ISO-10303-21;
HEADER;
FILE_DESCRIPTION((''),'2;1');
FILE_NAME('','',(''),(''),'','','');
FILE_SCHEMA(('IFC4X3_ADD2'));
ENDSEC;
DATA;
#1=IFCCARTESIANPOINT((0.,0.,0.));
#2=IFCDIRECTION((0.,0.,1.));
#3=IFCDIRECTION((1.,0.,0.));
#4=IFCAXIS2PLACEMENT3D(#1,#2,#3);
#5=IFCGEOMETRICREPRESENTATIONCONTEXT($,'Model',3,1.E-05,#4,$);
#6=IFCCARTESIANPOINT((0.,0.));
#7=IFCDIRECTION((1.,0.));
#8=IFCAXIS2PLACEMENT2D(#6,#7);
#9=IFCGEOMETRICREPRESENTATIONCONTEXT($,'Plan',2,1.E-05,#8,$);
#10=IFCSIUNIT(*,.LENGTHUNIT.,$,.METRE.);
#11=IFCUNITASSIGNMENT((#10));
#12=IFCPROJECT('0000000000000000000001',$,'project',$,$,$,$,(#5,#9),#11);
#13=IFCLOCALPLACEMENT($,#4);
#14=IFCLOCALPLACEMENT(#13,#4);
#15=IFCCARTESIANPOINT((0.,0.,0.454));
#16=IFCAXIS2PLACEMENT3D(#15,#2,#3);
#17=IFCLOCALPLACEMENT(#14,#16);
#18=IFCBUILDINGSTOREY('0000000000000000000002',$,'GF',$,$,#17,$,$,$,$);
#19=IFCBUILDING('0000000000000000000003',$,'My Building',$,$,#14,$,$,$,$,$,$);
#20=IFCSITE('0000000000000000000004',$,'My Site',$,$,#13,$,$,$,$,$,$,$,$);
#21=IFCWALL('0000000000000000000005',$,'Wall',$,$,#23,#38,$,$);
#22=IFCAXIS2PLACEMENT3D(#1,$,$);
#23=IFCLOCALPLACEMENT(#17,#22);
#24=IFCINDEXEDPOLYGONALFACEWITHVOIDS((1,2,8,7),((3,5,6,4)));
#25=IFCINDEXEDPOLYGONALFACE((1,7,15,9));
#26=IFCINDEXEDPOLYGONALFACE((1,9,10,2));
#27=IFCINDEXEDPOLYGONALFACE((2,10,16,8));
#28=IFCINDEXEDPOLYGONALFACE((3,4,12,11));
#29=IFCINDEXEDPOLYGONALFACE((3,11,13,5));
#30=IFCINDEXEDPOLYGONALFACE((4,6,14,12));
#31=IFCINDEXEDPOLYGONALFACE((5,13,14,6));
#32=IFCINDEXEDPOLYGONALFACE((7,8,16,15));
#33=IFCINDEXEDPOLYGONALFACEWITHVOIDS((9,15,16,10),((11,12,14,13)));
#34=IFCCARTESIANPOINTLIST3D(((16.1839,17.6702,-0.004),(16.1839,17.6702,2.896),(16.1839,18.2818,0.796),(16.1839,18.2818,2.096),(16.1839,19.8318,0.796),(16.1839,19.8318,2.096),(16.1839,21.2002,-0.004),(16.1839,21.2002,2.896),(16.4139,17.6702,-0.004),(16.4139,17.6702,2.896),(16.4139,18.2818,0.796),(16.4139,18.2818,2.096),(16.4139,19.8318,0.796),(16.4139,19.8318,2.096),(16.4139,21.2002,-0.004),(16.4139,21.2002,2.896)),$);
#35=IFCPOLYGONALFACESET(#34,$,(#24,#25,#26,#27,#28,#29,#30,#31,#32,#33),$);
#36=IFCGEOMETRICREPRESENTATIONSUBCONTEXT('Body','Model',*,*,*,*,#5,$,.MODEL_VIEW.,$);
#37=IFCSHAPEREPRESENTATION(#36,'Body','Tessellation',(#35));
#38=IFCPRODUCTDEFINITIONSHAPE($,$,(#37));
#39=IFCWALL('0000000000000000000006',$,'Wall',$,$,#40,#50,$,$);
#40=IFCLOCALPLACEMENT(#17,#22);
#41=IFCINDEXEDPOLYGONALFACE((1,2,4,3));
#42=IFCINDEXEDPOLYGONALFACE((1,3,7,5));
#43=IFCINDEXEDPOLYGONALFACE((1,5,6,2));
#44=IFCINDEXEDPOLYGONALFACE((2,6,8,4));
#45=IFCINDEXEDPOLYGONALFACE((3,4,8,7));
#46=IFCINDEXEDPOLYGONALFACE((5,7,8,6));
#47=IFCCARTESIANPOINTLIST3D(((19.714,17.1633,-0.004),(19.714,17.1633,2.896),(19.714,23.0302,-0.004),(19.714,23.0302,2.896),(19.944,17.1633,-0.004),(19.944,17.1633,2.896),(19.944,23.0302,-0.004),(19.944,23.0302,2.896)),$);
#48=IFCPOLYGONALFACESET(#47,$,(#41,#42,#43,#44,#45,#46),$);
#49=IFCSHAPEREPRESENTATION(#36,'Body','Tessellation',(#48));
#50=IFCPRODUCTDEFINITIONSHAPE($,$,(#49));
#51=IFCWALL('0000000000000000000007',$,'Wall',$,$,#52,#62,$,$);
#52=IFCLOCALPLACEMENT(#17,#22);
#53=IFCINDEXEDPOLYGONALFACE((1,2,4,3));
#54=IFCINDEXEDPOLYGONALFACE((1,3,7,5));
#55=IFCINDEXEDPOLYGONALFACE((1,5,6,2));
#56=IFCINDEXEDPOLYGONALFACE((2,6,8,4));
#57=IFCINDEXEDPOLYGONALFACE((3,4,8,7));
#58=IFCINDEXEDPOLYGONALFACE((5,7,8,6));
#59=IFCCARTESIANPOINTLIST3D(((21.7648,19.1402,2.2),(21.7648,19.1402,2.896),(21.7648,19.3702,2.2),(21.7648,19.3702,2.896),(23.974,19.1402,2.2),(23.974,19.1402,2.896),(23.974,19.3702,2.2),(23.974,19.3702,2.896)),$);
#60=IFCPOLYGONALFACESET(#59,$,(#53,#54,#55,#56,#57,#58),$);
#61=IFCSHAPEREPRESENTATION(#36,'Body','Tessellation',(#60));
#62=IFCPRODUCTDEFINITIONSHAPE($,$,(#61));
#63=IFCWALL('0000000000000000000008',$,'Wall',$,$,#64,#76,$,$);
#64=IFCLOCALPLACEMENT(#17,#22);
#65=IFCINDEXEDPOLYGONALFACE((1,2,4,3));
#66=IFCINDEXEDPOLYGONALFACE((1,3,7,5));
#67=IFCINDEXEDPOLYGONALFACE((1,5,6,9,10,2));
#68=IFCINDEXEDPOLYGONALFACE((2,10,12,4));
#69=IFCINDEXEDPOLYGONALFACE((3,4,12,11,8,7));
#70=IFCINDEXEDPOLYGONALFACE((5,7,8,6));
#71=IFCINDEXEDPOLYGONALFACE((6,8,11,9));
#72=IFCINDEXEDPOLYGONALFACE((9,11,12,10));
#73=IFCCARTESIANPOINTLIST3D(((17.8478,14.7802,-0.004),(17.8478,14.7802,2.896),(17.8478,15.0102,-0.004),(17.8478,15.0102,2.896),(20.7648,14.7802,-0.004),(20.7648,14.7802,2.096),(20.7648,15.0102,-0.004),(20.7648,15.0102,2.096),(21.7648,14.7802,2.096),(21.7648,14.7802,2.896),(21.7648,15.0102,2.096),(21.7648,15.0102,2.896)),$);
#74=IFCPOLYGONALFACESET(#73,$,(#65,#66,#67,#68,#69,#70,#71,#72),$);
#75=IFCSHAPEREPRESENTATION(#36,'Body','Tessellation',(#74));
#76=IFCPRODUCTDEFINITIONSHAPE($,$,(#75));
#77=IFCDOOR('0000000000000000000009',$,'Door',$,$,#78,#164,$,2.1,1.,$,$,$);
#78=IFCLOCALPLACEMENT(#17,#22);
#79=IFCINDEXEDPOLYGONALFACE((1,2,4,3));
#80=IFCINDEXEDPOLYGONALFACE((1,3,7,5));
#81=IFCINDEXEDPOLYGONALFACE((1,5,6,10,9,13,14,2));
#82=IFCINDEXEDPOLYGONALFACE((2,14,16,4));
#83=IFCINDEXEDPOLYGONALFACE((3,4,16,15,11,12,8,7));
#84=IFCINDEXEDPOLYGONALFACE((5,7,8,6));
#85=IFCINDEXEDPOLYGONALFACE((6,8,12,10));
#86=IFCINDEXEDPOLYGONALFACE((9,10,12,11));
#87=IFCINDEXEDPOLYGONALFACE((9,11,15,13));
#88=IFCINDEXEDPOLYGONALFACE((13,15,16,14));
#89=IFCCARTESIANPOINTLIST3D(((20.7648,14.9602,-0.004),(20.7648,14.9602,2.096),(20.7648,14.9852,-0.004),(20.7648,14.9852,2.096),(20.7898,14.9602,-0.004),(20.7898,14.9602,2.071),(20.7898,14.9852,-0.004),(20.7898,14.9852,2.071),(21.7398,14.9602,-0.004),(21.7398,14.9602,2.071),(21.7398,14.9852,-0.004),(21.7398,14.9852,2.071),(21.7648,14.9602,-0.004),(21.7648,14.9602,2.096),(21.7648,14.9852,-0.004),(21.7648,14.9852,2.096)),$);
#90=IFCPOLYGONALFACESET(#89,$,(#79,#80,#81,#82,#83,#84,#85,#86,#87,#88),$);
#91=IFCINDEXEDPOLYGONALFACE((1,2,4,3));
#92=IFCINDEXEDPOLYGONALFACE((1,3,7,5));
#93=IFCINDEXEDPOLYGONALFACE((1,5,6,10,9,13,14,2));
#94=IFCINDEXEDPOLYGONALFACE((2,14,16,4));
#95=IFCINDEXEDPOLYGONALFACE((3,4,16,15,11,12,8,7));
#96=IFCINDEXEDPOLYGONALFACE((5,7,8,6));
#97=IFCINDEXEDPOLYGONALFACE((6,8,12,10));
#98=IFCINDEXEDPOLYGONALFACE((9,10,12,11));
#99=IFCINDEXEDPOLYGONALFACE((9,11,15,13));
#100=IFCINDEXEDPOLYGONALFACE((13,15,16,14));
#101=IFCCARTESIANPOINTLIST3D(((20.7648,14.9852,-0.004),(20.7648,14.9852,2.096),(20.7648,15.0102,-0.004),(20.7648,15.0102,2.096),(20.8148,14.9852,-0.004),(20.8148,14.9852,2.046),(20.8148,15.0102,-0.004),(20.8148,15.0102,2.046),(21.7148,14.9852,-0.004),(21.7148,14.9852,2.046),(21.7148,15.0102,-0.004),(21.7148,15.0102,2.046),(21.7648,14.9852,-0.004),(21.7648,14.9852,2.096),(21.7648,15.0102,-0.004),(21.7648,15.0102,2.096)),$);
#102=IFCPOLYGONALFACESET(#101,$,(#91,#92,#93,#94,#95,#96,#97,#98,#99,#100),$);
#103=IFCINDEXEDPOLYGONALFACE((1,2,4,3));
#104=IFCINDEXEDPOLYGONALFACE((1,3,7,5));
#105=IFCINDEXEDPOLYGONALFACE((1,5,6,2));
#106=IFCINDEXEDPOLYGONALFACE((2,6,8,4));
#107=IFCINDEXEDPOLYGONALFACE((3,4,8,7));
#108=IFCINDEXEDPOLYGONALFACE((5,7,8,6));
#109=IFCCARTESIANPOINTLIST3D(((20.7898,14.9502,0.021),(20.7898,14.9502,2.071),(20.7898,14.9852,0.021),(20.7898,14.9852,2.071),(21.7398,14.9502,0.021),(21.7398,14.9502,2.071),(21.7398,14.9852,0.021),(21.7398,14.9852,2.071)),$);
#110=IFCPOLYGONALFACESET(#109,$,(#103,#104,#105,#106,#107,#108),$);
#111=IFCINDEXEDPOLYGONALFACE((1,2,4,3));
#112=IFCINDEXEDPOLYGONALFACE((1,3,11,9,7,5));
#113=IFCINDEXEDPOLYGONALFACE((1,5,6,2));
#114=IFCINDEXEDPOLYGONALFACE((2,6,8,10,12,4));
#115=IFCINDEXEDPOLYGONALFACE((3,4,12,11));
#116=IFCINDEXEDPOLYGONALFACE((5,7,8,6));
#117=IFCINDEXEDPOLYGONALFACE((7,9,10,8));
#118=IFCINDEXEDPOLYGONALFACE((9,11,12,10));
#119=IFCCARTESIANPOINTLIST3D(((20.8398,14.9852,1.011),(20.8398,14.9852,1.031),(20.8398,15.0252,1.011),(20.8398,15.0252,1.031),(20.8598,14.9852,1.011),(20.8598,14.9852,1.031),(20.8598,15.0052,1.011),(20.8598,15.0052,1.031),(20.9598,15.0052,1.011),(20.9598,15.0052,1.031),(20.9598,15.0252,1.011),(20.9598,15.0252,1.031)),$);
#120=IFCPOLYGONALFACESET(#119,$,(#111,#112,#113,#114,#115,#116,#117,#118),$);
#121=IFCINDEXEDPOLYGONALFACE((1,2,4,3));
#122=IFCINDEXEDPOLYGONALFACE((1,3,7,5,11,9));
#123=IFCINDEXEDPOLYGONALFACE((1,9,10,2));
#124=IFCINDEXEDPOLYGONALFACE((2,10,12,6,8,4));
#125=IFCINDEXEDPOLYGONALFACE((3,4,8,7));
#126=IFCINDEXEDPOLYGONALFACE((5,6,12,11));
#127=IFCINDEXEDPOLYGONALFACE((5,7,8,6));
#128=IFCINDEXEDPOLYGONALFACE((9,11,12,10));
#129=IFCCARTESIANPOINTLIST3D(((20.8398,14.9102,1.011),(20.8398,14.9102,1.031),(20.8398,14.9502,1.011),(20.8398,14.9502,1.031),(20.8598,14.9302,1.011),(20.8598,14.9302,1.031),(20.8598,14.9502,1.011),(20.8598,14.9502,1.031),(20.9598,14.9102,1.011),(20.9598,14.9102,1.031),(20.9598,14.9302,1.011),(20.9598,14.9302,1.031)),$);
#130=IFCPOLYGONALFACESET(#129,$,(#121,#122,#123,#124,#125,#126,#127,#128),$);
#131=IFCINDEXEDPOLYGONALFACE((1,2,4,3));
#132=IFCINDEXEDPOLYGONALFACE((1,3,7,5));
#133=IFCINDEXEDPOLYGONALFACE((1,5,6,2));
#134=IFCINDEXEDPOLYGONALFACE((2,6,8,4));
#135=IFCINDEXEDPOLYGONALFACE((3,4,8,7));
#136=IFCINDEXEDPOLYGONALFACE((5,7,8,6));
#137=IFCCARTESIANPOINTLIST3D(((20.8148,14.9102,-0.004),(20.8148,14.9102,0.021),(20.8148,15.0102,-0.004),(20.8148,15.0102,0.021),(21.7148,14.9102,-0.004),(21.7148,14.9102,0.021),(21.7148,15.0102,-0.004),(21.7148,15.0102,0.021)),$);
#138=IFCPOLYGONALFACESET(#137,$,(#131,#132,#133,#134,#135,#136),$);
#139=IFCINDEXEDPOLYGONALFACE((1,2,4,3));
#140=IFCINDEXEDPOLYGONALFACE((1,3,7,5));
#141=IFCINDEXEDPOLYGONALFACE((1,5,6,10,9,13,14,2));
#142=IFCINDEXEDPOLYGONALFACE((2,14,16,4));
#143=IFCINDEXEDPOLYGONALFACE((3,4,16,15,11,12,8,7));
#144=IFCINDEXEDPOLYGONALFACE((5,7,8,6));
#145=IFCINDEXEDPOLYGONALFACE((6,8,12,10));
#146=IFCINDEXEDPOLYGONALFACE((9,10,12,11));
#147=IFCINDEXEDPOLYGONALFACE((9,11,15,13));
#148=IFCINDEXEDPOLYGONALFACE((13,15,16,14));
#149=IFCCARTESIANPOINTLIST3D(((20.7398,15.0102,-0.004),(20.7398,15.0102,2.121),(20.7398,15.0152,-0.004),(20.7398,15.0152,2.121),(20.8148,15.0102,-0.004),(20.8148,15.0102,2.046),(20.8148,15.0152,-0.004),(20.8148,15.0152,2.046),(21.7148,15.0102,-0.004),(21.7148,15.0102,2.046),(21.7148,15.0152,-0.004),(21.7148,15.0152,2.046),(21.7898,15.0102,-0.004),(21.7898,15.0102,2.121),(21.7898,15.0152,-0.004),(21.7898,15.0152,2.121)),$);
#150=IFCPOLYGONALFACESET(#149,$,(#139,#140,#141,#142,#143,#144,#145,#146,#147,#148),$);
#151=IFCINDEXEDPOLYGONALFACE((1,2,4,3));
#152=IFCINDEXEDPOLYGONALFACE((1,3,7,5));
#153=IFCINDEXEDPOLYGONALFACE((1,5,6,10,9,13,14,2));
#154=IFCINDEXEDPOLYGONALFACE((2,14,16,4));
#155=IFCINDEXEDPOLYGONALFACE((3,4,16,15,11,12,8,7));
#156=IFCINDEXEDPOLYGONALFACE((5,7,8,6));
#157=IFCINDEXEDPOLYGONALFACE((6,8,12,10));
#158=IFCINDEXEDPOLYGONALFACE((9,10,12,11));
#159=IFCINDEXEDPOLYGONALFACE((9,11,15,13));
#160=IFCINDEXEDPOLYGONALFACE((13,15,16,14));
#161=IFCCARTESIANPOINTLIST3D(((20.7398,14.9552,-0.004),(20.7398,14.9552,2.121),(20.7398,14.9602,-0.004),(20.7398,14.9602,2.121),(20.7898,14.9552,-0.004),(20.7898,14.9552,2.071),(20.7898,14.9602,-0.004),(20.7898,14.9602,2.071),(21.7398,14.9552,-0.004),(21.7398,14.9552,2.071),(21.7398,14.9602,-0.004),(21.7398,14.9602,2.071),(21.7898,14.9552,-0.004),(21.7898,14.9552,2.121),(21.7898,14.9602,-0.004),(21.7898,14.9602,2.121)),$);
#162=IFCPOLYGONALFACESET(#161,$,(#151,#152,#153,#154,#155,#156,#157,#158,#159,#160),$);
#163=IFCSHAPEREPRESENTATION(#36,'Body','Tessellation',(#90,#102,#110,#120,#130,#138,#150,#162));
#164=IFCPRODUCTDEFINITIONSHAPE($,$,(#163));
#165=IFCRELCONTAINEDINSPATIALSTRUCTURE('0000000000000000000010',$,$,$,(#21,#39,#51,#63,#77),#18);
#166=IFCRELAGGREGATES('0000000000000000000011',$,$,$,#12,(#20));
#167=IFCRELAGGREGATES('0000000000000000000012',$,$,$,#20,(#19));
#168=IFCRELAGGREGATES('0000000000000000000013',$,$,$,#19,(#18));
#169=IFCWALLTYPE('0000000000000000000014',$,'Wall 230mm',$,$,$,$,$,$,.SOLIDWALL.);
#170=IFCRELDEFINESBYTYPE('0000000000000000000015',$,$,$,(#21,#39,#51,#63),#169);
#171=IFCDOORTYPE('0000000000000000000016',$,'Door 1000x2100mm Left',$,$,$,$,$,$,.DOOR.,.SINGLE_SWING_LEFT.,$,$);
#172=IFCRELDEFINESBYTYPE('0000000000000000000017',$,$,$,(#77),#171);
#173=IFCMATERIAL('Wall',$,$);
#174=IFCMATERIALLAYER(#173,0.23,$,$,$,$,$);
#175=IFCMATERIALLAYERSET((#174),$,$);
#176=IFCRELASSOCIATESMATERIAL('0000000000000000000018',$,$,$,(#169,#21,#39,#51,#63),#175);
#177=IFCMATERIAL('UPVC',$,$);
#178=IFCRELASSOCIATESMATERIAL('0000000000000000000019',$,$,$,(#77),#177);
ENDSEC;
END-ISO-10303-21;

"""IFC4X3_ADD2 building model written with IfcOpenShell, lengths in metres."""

from ifc_helpers import new_model, entity, si_unit, frame, origin_with_axes, origin_2d_with_axis, place, context, subcontext, project, spatial, line, indexed_curve, outline, extrude, clip, halfspace, shape, source, transform, mapped, material, layer, layer_set, layer_usage, type_object, type_shapes, element, fill, save


model = new_model("IFC4X3_ADD2")

# Units and contexts
model_context = context("Model", 3, precision=1e-05, world=origin_with_axes())
plan_context = context("Plan", 2, precision=1e-05, world=origin_2d_with_axis())
body_context_1 = subcontext(model_context, "Body", "Model", "MODEL_VIEW")
body_context_2 = subcontext(plan_context, "Body", "Plan", "PLAN_VIEW")
ifc_project = project(units=[si_unit("LENGTHUNIT", "METRE")], contexts=[model_context, plan_context])

# Site, building, storey
site_placement = place(None, origin_with_axes())
site = spatial("IfcSite", under=ifc_project, at=site_placement, Name="My Site")
building_placement = place(site_placement, origin_with_axes())
building = spatial("IfcBuilding", under=site, at=building_placement, Name="My Building")
storey_placement = place(building_placement, frame((0.0, 0.0, 0.454), z_axis=(0.0, 0.0, 1.0), x_axis=(1.0, 0.0, 0.0)))
storey = spatial("IfcBuildingStorey", under=building, at=storey_placement, Name="GF")

# Shared definitions
ifc_material_1 = material(Name="Wall")

# Wall, opening
ifc_layer_1 = layer(ifc_material_1, 0.23)
ifc_layer_set_1 = layer_set([ifc_layer_1])
wall_type_1 = type_object("IfcWallType", Name="Wall 230mm", PredefinedType="SOLIDWALL", material=ifc_layer_set_1)
shared_shape_1 = source(origin_with_axes(), body_context_1, "Body", "SweptSolid", [
    extrude(outline(indexed_curve([(0.0, 0.0), (1.55, 0.0), (1.55, 1.3), (0.0, 1.3)], segments=[line(1, 2, 3, 4, 1)])), frame((-0.775, -0.6, 0.0), z_axis=(0.0, -1.0, 0.0), x_axis=(1.0, 0.0, 0.0)), (0.0, 0.0, -1.0), 1.2),
])
ifc_layer_usage_1 = layer_usage(ifc_layer_set_1, "AXIS2", "POSITIVE", 0.0)
wall_1_placement = place(storey_placement, frame((16.4139, 17.6702, -0.004), z_axis=(0.0, 0.0, 1.0), x_axis=(0.000001, 1.0, 0.0)))
wall_1 = element("IfcWall", 1, at=wall_1_placement, inside=storey, type_object=wall_type_1, material=ifc_layer_usage_1, Name="Wall", context=body_context_1, shape_type="SweptSolid", body=[
    extrude(outline(indexed_curve([(0.0, 0.0), (0.0, 0.23), (3.53, 0.23), (3.53, 0.0), (0.0, 0.0)], self_intersect=False)), origin_with_axes(), (0.0, 0.0, 1.0), 2.9),
])
opening_1_placement = place(wall_1_placement, frame((1.3866, 0.0, 0.8), z_axis=(0.0, 0.0, 1.0), x_axis=(1.0, 0.0, 0.0)))
element("IfcOpeningElement", 2, at=opening_1_placement, cuts=wall_1, PredefinedType="OPENING", context=body_context_1, shape_type="MappedRepresentation", body=[
    mapped(shared_shape_1, transform((0.0, 0.0, 0.0), x_axis=(1.0, 0.0, 0.0), y_axis=(0.0, 1.0, 0.0), z_axis=(0.0, 0.0, 1.0), scale=1.0)),
])

# Walls
ifc_layer_usage_2 = layer_usage(ifc_layer_set_1, "AXIS2", "POSITIVE", 0.0)
wall_2_placement = place(storey_placement, frame((19.944, 17.1633, -0.004), z_axis=(0.0, 0.0, 1.0), x_axis=(0.000001, 1.0, 0.0)))
element("IfcWall", 3, at=wall_2_placement, inside=storey, type_object=wall_type_1, material=ifc_layer_usage_2, Name="Wall", context=body_context_1, shape_type="SweptSolid", body=[
    extrude(outline(indexed_curve([(0.0, 0.0), (0.0, 0.23), (5.8669, 0.23), (5.8669, 0.0), (0.0, 0.0)], self_intersect=False)), origin_with_axes(), (0.0, 0.0, 1.0), 2.9),
])
ifc_layer_usage_3 = layer_usage(ifc_layer_set_1, "AXIS2", "POSITIVE", 0.0)
wall_3_placement = place(storey_placement, frame((23.974, 19.3702, 2.2), z_axis=(0.0, 0.0, 1.0), x_axis=(-1.0, 0.0, 0.0)))
element("IfcWall", 4, at=wall_3_placement, inside=storey, type_object=wall_type_1, material=ifc_layer_usage_3, Name="Wall", context=body_context_1, shape_type="Clipping", body=[
    clip(extrude(outline(indexed_curve([(0.0, 0.0), (0.0, 0.23), (2.2092, 0.23), (2.2092, 0.0), (0.0, 0.0)], self_intersect=False)), origin_with_axes(), (0.0, 0.0, 1.0), 3.35), halfspace(frame((0.0, 0.0, 0.696), z_axis=(0.0, 0.0, 1.0), x_axis=(-1.0, 0.0, 0.0)), False)),
])

# Wall, opening, door
ifc_layer_usage_4 = layer_usage(ifc_layer_set_1, "AXIS2", "POSITIVE", 0.0)
wall_4_placement = place(storey_placement, frame((21.7648, 15.0102, -0.004), z_axis=(0.0, 0.0, 1.0), x_axis=(-1.0, 0.0, 0.0)))
wall_4 = element("IfcWall", 5, at=wall_4_placement, inside=storey, type_object=wall_type_1, material=ifc_layer_usage_4, Name="Wall", context=body_context_1, shape_type="SweptSolid", body=[
    extrude(outline(indexed_curve([(0.0, 0.0), (0.0, 0.23), (3.917, 0.23), (3.917, 0.0), (0.0, 0.0)], self_intersect=False)), origin_with_axes(), (0.0, 0.0, 1.0), 2.9),
])
shared_shape_2 = source(origin_with_axes(), body_context_1, "Body", "SweptSolid", [
    extrude(outline(indexed_curve([(0.0, 0.0), (1.0, 0.0), (1.0, 2.1), (0.0, 2.1)], segments=[line(1, 2, 3, 4, 1)])), frame((0.0, -0.6, 0.0), z_axis=(0.0, -1.0, 0.0), x_axis=(1.0, 0.0, 0.0)), (0.0, 0.0, -1.0), 1.2),
])
opening_2_placement = place(wall_4_placement, frame((0.0, 0.0, 0.0), z_axis=(0.0, 0.0, 1.0), x_axis=(1.0, 0.0, 0.0)))
opening_2 = element("IfcOpeningElement", 6, at=opening_2_placement, cuts=wall_4, PredefinedType="OPENING", context=body_context_1, shape_type="MappedRepresentation", body=[
    mapped(shared_shape_2, transform((0.0, 0.0, 0.0), x_axis=(1.0, 0.0, 0.0), y_axis=(0.0, 1.0, 0.0), z_axis=(0.0, 0.0, 1.0), scale=1.0)),
])
ifc_material_2 = material(Name="UPVC")
door_type_1 = type_object("IfcDoorType", Name="Door 1000x2100mm Left", OperationType="SINGLE_SWING_LEFT", PredefinedType="DOOR")
shared_shape_3 = source(origin_with_axes(), body_context_1, "Body", "SweptSolid", [
    extrude(outline(indexed_curve([(0.0, 0.0), (0.0, 2.1), (1.0, 2.1), (1.0, 0.0), (0.975, 0.0), (0.975, 2.075), (0.025, 2.075), (0.025, 0.0)], segments=[line(1, 2, 3, 4, 5, 6, 7, 8, 1)])), frame((0.0, 0.025, 0.0), z_axis=(0.0, -1.0, 0.0), x_axis=(1.0, 0.0, 0.0)), (0.0, 0.0, -1.0), 0.025),
    extrude(outline(indexed_curve([(0.0, 0.0), (0.0, 2.1), (1.0, 2.1), (1.0, 0.0), (0.95, 0.0), (0.95, 2.05), (0.05, 2.05), (0.05, 0.0)], segments=[line(1, 2, 3, 4, 5, 6, 7, 8, 1)])), frame((0.0, 0.0, 0.0), z_axis=(0.0, -1.0, 0.0), x_axis=(1.0, 0.0, 0.0)), (0.0, 0.0, -1.0), 0.025),
    extrude(outline(indexed_curve([(0.0, 0.0), (0.95, 0.0), (0.95, 0.035), (0.0, 0.035)], segments=[line(1, 2, 3, 4, 1)])), frame((0.025, 0.025, 0.025), z_axis=(0.0, 0.0, 1.0), x_axis=(1.0, 0.0, 0.0)), (0.0, 0.0, 1.0), 2.05),
    extrude(outline(indexed_curve([(0.0, 0.0), (0.0, -0.04), (-0.12, -0.04), (-0.12, -0.02), (-0.02, -0.02), (-0.02, 0.0)], segments=[line(1, 2, 3, 4, 5, 6, 1)])), frame((0.925, 0.025, 1.015), z_axis=(0.0, 0.0, 1.0), x_axis=(1.0, 0.0, 0.0)), (0.0, 0.0, 1.0), 0.02),
    extrude(outline(indexed_curve([(0.0, 0.0), (0.0, 0.04), (-0.12, 0.04), (-0.12, 0.02), (-0.02, 0.02), (-0.02, 0.0)], segments=[line(1, 2, 3, 4, 5, 6, 1)])), frame((0.925, 0.06, 1.015), z_axis=(0.0, 0.0, 1.0), x_axis=(1.0, 0.0, 0.0)), (0.0, 0.0, 1.0), 0.02),
    extrude(outline(indexed_curve([(0.0, 0.0), (0.9, 0.0), (0.9, 0.1), (0.0, 0.1)], segments=[line(1, 2, 3, 4, 1)])), frame((0.05, 0.0, 0.0), z_axis=(0.0, 0.0, 1.0), x_axis=(1.0, 0.0, 0.0)), (0.0, 0.0, 1.0), 0.025),
    extrude(outline(indexed_curve([(0.0, 0.0), (0.0, 2.125), (1.05, 2.125), (1.05, 0.0), (0.975, 0.0), (0.975, 2.05), (0.075, 2.05), (0.075, 0.0)], segments=[line(1, 2, 3, 4, 5, 6, 7, 8, 1)])), frame((-0.025, -0.005, 0.0), z_axis=(0.0, -1.0, 0.0), x_axis=(1.0, 0.0, 0.0)), (0.0, 0.0, -1.0), 0.005),
    extrude(outline(indexed_curve([(0.0, 0.0), (0.0, 2.125), (1.05, 2.125), (1.05, 0.0), (1.0, 0.0), (1.0, 2.075), (0.05, 2.075), (0.05, 0.0)], segments=[line(1, 2, 3, 4, 5, 6, 7, 8, 1)])), frame((-0.025, 0.05, 0.0), z_axis=(0.0, -1.0, 0.0), x_axis=(1.0, 0.0, 0.0)), (0.0, 0.0, -1.0), 0.005),
])
shared_shape_4 = source(origin_with_axes(), body_context_2, "Body", "Curve2D", [
    entity("IfcIndexedPolyCurve", entity("IfcCartesianPointList2D", [[0.0, 0.0], [0.0, 0.05], [0.025, 0.05], [0.025, 0.025], [0.05, 0.025], [0.05, 0.0]]), [entity("IfcLineIndex", [1, 2, 3, 4, 5, 6, 1])]),
    entity("IfcIndexedPolyCurve", entity("IfcCartesianPointList2D", [[1.0, 0.0], [1.0, 0.05], [0.975, 0.05], [0.975, 0.025], [0.95, 0.025], [0.95, 0.0]]), [entity("IfcLineIndex", [1, 2, 3, 4, 5, 6, 1])]),
    entity("IfcTrimmedCurve", entity("IfcEllipse", entity("IfcAxis2Placement2D", entity("IfcCartesianPoint", [0.06, 0.05]), entity("IfcDirection", [1.0, 0.0])), 0.915, 0.95), [entity("IfcCartesianPoint", [0.975, 0.05])], [entity("IfcCartesianPoint", [0.06, 1.0])], True, "CARTESIAN"),
    entity("IfcIndexedPolyCurve", entity("IfcCartesianPointList2D", [[0.025, 0.05], [0.06, 0.05], [0.06, 1.0], [0.025, 1.0]]), [entity("IfcLineIndex", [1, 2, 3, 4, 1])]),
])
type_shapes(door_type_1, [shared_shape_3, shared_shape_4])
door_1_placement = place(opening_2_placement, frame((0.0, 0.0, 0.0), z_axis=(0.0, 0.0, 1.0), x_axis=(1.0, 0.0, 0.0)))
door_1 = element("IfcDoor", 7, at=door_1_placement, inside=storey, type_object=door_type_1, material=ifc_material_2, Name="Door", OverallHeight=2.1, OverallWidth=1.0, shapes=[
    shape(body_context_1, "Body", "MappedRepresentation", [mapped(shared_shape_3, transform((0.0, 0.0, 0.0), x_axis=(1.0, 0.0, 0.0), y_axis=(0.0, 1.0, 0.0), z_axis=(0.0, 0.0, 1.0), scale=1.0))]),
    shape(body_context_2, "Body", "MappedRepresentation", [mapped(shared_shape_4, transform((0.0, 0.0, 0.0), x_axis=(1.0, 0.0, 0.0), y_axis=(0.0, 1.0, 0.0), z_axis=(0.0, 0.0, 1.0), scale=1.0))]),
])
fill(opening_2, door_1)

save(model, "model.ifc")
